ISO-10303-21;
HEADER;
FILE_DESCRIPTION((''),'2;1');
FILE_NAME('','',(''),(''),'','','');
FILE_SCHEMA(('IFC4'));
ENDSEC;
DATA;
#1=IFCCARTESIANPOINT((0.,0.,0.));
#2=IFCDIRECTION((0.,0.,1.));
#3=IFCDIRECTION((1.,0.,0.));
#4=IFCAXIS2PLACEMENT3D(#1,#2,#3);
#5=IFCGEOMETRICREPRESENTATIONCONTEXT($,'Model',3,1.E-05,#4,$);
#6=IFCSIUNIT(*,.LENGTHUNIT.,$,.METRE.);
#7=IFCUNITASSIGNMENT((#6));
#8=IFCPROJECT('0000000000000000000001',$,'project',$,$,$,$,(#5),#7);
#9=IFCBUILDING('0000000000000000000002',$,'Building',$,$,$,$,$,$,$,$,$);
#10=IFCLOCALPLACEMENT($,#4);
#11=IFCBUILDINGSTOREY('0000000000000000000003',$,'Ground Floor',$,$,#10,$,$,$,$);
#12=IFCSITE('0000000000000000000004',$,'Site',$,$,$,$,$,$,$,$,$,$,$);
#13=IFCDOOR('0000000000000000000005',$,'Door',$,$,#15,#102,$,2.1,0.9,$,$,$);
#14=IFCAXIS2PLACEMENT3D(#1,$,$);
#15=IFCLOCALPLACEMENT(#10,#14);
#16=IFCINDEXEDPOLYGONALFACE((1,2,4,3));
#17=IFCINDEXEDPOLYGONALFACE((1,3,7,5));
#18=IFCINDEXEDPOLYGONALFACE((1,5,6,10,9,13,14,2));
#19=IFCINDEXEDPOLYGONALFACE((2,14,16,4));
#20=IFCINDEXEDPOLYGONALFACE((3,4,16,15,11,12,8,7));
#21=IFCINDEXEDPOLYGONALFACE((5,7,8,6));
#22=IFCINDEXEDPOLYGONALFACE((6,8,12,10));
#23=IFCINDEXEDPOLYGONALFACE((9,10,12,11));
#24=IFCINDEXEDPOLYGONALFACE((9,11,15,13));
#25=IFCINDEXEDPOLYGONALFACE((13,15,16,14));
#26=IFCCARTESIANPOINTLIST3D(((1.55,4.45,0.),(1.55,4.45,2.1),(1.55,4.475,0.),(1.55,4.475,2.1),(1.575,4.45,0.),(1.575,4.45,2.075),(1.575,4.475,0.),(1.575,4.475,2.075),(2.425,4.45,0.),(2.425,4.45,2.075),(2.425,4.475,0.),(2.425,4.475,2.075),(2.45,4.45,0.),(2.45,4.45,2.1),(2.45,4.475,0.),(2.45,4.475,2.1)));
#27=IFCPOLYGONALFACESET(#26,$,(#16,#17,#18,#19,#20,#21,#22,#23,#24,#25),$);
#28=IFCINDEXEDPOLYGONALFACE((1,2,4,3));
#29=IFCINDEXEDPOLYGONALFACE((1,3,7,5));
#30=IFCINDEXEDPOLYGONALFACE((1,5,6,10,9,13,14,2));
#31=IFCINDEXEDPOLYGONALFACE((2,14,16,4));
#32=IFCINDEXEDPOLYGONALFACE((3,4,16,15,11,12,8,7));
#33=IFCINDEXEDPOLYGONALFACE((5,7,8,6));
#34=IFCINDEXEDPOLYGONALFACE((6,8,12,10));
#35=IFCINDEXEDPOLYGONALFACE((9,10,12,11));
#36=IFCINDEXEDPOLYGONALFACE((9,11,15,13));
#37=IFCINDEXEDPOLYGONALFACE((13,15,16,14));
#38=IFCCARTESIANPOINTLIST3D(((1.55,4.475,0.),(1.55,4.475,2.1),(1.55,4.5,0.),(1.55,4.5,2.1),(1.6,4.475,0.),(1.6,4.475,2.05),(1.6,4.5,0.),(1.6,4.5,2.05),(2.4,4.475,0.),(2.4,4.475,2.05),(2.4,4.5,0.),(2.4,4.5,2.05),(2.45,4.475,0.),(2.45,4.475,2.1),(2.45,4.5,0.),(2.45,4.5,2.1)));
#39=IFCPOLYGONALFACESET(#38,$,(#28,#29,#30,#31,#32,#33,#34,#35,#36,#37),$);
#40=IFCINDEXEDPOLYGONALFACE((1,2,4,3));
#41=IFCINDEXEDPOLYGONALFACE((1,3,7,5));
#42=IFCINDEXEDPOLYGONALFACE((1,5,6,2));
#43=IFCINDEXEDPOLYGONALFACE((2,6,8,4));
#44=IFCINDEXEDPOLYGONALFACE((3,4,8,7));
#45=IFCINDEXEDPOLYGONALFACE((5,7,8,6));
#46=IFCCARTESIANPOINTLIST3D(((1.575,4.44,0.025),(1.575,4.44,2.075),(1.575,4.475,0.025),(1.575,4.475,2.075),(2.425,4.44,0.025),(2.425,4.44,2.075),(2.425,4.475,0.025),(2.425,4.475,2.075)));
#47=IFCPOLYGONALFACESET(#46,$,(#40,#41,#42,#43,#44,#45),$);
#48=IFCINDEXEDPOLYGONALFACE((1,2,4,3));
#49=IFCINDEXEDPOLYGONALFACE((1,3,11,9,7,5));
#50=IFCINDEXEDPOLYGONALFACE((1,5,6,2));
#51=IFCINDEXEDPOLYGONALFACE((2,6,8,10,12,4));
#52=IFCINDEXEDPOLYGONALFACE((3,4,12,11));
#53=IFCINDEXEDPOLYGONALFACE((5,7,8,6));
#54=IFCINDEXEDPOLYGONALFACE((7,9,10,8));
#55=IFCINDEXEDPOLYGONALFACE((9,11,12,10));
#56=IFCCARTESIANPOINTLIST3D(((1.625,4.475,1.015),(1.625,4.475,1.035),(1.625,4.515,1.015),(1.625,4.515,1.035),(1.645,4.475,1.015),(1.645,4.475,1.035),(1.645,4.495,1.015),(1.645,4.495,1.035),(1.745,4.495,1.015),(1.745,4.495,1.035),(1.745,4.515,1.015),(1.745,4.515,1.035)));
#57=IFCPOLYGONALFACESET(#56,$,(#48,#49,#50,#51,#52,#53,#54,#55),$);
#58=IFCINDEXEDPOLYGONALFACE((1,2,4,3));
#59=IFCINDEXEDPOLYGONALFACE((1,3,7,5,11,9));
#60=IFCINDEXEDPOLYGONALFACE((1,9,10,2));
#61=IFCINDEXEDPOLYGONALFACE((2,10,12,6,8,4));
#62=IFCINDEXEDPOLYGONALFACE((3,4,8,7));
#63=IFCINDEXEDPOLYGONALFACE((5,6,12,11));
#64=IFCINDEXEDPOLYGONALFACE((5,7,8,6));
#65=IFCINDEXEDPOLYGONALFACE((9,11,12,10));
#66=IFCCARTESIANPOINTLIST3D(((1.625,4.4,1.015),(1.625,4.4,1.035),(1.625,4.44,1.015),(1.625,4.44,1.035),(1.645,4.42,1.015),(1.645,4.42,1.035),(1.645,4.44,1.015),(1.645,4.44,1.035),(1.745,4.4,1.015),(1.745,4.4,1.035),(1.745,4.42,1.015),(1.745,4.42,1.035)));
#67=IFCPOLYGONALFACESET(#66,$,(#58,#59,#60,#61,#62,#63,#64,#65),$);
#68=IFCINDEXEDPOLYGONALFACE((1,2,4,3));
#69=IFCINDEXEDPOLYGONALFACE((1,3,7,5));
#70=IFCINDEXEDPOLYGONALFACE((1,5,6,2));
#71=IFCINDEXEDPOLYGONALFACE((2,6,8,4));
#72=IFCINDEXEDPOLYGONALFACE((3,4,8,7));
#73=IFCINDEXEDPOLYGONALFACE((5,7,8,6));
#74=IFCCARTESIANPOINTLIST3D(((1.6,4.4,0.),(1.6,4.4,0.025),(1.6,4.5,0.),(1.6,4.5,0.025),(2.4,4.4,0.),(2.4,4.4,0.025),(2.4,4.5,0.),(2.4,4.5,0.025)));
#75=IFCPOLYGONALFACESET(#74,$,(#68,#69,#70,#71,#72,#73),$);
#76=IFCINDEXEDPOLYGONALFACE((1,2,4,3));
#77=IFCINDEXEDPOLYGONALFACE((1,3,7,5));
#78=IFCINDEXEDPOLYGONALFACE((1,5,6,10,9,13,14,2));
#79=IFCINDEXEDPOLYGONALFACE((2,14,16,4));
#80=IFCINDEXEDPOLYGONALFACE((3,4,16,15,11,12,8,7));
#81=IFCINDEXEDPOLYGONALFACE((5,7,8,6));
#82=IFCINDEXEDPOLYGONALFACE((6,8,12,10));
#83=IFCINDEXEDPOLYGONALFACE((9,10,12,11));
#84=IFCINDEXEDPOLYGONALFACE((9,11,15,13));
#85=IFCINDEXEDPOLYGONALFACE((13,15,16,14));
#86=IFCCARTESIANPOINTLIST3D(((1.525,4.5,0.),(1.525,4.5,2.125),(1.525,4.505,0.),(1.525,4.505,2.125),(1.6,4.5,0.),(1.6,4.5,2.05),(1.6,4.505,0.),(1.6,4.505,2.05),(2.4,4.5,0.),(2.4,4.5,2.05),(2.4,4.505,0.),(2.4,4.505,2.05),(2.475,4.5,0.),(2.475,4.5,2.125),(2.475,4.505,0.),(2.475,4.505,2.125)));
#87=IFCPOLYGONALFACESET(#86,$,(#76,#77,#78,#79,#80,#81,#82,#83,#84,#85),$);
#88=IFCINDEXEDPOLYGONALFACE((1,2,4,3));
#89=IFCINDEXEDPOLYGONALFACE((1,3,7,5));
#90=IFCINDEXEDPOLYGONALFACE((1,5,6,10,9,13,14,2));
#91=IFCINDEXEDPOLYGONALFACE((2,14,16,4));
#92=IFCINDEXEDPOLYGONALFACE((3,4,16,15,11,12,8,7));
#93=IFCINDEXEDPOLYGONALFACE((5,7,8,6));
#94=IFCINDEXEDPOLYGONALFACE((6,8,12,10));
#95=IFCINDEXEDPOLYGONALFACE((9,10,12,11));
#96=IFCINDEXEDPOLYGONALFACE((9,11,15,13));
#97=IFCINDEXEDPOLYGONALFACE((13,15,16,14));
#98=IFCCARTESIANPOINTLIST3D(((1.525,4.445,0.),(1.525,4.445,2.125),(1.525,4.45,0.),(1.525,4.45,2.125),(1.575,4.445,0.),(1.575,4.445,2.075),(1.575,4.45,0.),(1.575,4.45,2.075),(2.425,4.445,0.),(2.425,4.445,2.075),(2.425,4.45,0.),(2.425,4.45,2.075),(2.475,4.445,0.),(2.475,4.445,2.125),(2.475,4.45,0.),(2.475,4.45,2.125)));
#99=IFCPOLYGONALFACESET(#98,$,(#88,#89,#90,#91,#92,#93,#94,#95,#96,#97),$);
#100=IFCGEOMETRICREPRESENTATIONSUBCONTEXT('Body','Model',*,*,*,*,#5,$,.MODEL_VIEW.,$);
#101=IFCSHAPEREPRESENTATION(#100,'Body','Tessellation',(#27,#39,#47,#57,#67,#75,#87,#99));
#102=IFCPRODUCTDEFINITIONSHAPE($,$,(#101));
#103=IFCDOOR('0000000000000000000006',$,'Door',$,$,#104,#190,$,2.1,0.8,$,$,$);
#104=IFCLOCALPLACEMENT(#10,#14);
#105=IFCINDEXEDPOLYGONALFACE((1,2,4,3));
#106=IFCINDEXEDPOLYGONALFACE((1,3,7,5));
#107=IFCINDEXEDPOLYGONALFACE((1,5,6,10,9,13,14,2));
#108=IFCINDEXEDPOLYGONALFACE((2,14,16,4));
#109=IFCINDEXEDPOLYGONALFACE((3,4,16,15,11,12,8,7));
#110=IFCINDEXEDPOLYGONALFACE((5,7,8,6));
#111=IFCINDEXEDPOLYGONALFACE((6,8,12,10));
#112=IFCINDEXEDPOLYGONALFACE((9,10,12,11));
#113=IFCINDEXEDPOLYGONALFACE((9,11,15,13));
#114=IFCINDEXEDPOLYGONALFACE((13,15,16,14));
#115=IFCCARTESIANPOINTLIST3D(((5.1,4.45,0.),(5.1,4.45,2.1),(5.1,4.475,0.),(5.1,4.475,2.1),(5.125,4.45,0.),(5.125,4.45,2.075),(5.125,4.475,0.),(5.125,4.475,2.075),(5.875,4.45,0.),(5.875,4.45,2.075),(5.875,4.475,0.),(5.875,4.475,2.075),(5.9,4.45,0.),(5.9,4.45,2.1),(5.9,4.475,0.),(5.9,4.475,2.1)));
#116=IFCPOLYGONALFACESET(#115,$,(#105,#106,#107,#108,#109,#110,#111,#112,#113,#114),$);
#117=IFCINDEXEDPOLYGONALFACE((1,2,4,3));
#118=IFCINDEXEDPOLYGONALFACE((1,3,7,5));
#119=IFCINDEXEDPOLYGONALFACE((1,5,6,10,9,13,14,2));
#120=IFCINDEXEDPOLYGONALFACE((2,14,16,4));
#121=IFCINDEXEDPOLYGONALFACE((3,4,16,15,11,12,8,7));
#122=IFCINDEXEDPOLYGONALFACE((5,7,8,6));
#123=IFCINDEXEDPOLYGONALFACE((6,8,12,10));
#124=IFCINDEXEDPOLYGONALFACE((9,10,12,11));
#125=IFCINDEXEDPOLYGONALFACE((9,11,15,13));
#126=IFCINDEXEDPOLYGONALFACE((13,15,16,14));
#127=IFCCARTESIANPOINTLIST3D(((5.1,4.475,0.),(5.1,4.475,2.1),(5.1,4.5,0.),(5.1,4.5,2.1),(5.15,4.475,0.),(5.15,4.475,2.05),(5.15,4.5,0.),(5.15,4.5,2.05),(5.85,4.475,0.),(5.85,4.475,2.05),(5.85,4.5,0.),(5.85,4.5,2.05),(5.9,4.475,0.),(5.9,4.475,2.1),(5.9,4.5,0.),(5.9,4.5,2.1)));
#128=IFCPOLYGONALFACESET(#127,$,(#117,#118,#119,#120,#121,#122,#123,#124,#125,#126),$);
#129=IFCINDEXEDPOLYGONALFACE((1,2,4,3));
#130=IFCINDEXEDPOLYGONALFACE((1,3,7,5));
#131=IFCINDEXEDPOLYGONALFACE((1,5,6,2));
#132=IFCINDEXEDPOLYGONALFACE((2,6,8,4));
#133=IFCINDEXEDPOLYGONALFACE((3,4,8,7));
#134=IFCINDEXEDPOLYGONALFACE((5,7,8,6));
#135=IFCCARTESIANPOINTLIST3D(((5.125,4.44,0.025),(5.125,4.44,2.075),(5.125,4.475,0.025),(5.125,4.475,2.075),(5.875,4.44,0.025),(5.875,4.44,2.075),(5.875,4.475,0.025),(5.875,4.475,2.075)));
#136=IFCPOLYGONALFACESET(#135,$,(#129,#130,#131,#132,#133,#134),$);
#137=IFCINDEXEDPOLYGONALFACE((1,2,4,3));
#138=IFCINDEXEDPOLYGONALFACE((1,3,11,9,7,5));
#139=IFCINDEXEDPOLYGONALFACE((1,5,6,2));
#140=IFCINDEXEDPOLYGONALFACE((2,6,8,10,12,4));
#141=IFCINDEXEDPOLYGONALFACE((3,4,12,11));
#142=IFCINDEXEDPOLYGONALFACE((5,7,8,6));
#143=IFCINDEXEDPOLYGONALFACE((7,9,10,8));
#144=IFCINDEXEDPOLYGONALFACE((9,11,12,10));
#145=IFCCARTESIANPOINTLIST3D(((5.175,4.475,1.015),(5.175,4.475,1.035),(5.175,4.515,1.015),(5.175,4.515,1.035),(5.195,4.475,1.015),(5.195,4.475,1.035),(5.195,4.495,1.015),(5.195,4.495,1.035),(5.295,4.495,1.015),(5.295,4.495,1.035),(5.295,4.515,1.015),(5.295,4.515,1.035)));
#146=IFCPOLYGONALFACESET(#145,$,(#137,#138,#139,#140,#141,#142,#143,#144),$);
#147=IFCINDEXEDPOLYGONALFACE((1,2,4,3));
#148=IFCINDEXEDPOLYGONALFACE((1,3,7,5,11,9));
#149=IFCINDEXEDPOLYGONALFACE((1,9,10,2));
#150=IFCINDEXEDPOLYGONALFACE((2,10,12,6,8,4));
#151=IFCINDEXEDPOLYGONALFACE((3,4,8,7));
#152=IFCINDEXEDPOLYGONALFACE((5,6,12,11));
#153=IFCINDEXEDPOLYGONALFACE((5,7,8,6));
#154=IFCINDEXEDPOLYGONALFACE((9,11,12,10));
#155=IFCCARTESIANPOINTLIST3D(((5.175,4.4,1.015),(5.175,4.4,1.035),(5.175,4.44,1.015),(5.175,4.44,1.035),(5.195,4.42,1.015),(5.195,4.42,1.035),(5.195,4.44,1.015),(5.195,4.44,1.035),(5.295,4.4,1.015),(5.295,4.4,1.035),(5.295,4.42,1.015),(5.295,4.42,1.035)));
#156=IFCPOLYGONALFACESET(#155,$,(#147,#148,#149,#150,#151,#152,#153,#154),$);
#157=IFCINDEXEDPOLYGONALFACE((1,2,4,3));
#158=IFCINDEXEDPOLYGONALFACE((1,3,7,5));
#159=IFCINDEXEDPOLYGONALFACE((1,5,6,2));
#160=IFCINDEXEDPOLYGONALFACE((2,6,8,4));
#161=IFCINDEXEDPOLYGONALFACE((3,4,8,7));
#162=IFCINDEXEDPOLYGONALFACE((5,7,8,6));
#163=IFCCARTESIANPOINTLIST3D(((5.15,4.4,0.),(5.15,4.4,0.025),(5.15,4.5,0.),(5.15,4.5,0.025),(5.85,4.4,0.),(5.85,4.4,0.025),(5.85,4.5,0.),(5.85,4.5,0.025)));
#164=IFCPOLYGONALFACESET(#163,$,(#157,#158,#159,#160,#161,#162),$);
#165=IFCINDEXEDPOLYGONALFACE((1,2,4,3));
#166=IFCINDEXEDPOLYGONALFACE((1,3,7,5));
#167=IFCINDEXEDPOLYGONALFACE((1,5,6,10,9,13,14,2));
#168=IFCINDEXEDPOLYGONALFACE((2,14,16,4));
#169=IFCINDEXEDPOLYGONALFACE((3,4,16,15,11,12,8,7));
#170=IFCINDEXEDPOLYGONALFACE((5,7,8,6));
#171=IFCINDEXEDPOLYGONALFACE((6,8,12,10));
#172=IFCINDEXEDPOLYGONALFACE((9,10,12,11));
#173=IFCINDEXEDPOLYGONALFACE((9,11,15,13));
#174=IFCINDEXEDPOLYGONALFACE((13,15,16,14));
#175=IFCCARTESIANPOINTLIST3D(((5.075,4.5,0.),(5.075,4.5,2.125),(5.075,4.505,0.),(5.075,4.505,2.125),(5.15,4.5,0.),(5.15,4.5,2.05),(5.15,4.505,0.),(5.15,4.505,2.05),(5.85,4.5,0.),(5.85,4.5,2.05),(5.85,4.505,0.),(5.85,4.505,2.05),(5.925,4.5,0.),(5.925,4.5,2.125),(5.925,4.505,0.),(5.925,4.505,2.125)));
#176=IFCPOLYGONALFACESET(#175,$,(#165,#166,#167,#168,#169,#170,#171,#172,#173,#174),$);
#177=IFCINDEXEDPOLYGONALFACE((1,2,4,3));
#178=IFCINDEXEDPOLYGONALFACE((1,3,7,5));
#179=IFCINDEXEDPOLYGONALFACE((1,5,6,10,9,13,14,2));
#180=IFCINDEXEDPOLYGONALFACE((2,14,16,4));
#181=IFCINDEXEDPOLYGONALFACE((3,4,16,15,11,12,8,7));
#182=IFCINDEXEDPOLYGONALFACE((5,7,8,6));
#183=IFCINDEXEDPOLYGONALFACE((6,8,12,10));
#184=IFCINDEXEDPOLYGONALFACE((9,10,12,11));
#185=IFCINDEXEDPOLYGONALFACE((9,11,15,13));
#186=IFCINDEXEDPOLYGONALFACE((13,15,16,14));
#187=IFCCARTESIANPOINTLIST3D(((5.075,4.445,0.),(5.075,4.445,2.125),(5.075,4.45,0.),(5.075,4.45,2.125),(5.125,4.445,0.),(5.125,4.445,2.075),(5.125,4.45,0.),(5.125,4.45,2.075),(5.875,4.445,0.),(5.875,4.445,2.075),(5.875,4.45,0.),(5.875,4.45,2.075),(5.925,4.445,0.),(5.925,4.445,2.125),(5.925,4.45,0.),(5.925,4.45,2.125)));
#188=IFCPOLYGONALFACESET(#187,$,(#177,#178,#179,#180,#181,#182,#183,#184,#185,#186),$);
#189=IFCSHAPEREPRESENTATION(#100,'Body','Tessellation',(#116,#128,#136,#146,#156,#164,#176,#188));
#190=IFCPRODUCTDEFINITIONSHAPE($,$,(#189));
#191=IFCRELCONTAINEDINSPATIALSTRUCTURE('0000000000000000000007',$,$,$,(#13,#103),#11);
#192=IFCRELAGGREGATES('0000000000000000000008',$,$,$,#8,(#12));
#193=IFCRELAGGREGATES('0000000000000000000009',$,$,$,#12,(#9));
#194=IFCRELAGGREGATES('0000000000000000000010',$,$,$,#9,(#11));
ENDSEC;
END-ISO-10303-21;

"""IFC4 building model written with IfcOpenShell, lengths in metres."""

from ifc_helpers import new_model, si_unit, frame, origin_with_axes, place, context, subcontext, project, spatial, line, indexed_curve, outline, extrude, element, save


model = new_model("IFC4")

# Units and contexts
model_context = context("Model", 3, precision=1e-05, world=origin_with_axes())
body_context = subcontext(model_context, "Body", "Model", "MODEL_VIEW")
ifc_project = project(units=[si_unit("LENGTHUNIT", "METRE")], contexts=[model_context])

# Site, building, storey
site = spatial("IfcSite", under=ifc_project, Name="Site")
building = spatial("IfcBuilding", under=site, Name="Building")
storey_placement = place(None, origin_with_axes())
storey = spatial("IfcBuildingStorey", under=building, at=storey_placement, Name="Ground Floor")

# Doors
door_1_placement = place(storey_placement, frame((2.45, 4.5, 0.0), z_axis=(0.0, 0.0, 1.0), x_axis=(-1.0, 0.0, 0.0)))
element("IfcDoor", 1, at=door_1_placement, inside=storey, Name="Door", OverallHeight=2.1, OverallWidth=0.9, context=body_context, shape_type="SweptSolid", body=[
    extrude(outline(indexed_curve([(0.0, 0.0), (0.0, 2.1), (0.9, 2.1), (0.9, 0.0), (0.875, 0.0), (0.875, 2.075), (0.025, 2.075), (0.025, 0.0)], segments=[line(1, 2, 3, 4, 5, 6, 7, 8, 1)])), frame((0.0, 0.025, 0.0), z_axis=(0.0, -1.0, 0.0), x_axis=(1.0, 0.0, 0.0)), (0.0, 0.0, -1.0), 0.025),
    extrude(outline(indexed_curve([(0.0, 0.0), (0.0, 2.1), (0.9, 2.1), (0.9, 0.0), (0.85, 0.0), (0.85, 2.05), (0.05, 2.05), (0.05, 0.0)], segments=[line(1, 2, 3, 4, 5, 6, 7, 8, 1)])), frame((0.0, 0.0, 0.0), z_axis=(0.0, -1.0, 0.0), x_axis=(1.0, 0.0, 0.0)), (0.0, 0.0, -1.0), 0.025),
    extrude(outline(indexed_curve([(0.0, 0.0), (0.85, 0.0), (0.85, 0.035), (0.0, 0.035)], segments=[line(1, 2, 3, 4, 1)])), frame((0.025, 0.025, 0.025), z_axis=(0.0, 0.0, 1.0), x_axis=(1.0, 0.0, 0.0)), (0.0, 0.0, 1.0), 2.05),
    extrude(outline(indexed_curve([(0.0, 0.0), (0.0, -0.04), (-0.12, -0.04), (-0.12, -0.02), (-0.02, -0.02), (-0.02, 0.0)], segments=[line(1, 2, 3, 4, 5, 6, 1)])), frame((0.825, 0.025, 1.015), z_axis=(0.0, 0.0, 1.0), x_axis=(1.0, 0.0, 0.0)), (0.0, 0.0, 1.0), 0.02),
    extrude(outline(indexed_curve([(0.0, 0.0), (0.0, 0.04), (-0.12, 0.04), (-0.12, 0.02), (-0.02, 0.02), (-0.02, 0.0)], segments=[line(1, 2, 3, 4, 5, 6, 1)])), frame((0.825, 0.06, 1.015), z_axis=(0.0, 0.0, 1.0), x_axis=(1.0, 0.0, 0.0)), (0.0, 0.0, 1.0), 0.02),
    extrude(outline(indexed_curve([(0.0, 0.0), (0.8, 0.0), (0.8, 0.1), (0.0, 0.1)], segments=[line(1, 2, 3, 4, 1)])), frame((0.05, 0.0, 0.0), z_axis=(0.0, 0.0, 1.0), x_axis=(1.0, 0.0, 0.0)), (0.0, 0.0, 1.0), 0.025),
    extrude(outline(indexed_curve([(0.0, 0.0), (0.0, 2.125), (0.95, 2.125), (0.95, 0.0), (0.875, 0.0), (0.875, 2.05), (0.075, 2.05), (0.075, 0.0)], segments=[line(1, 2, 3, 4, 5, 6, 7, 8, 1)])), frame((-0.025, -0.005, 0.0), z_axis=(0.0, -1.0, 0.0), x_axis=(1.0, 0.0, 0.0)), (0.0, 0.0, -1.0), 0.005),
    extrude(outline(indexed_curve([(0.0, 0.0), (0.0, 2.125), (0.95, 2.125), (0.95, 0.0), (0.9, 0.0), (0.9, 2.075), (0.05, 2.075), (0.05, 0.0)], segments=[line(1, 2, 3, 4, 5, 6, 7, 8, 1)])), frame((-0.025, 0.05, 0.0), z_axis=(0.0, -1.0, 0.0), x_axis=(1.0, 0.0, 0.0)), (0.0, 0.0, -1.0), 0.005),
])
door_2_placement = place(storey_placement, frame((5.9, 4.5, 0.0), z_axis=(0.0, 0.0, 1.0), x_axis=(-1.0, 0.0, 0.0)))
element("IfcDoor", 2, at=door_2_placement, inside=storey, Name="Door", OverallHeight=2.1, OverallWidth=0.8, context=body_context, shape_type="SweptSolid", body=[
    extrude(outline(indexed_curve([(0.0, 0.0), (0.0, 2.1), (0.8, 2.1), (0.8, 0.0), (0.775, 0.0), (0.775, 2.075), (0.025, 2.075), (0.025, 0.0)], segments=[line(1, 2, 3, 4, 5, 6, 7, 8, 1)])), frame((0.0, 0.025, 0.0), z_axis=(0.0, -1.0, 0.0), x_axis=(1.0, 0.0, 0.0)), (0.0, 0.0, -1.0), 0.025),
    extrude(outline(indexed_curve([(0.0, 0.0), (0.0, 2.1), (0.8, 2.1), (0.8, 0.0), (0.75, 0.0), (0.75, 2.05), (0.05, 2.05), (0.05, 0.0)], segments=[line(1, 2, 3, 4, 5, 6, 7, 8, 1)])), frame((0.0, 0.0, 0.0), z_axis=(0.0, -1.0, 0.0), x_axis=(1.0, 0.0, 0.0)), (0.0, 0.0, -1.0), 0.025),
    extrude(outline(indexed_curve([(0.0, 0.0), (0.75, 0.0), (0.75, 0.035), (0.0, 0.035)], segments=[line(1, 2, 3, 4, 1)])), frame((0.025, 0.025, 0.025), z_axis=(0.0, 0.0, 1.0), x_axis=(1.0, 0.0, 0.0)), (0.0, 0.0, 1.0), 2.05),
    extrude(outline(indexed_curve([(0.0, 0.0), (0.0, -0.04), (-0.12, -0.04), (-0.12, -0.02), (-0.02, -0.02), (-0.02, 0.0)], segments=[line(1, 2, 3, 4, 5, 6, 1)])), frame((0.725, 0.025, 1.015), z_axis=(0.0, 0.0, 1.0), x_axis=(1.0, 0.0, 0.0)), (0.0, 0.0, 1.0), 0.02),
    extrude(outline(indexed_curve([(0.0, 0.0), (0.0, 0.04), (-0.12, 0.04), (-0.12, 0.02), (-0.02, 0.02), (-0.02, 0.0)], segments=[line(1, 2, 3, 4, 5, 6, 1)])), frame((0.725, 0.06, 1.015), z_axis=(0.0, 0.0, 1.0), x_axis=(1.0, 0.0, 0.0)), (0.0, 0.0, 1.0), 0.02),
    extrude(outline(indexed_curve([(0.0, 0.0), (0.7, 0.0), (0.7, 0.1), (0.0, 0.1)], segments=[line(1, 2, 3, 4, 1)])), frame((0.05, 0.0, 0.0), z_axis=(0.0, 0.0, 1.0), x_axis=(1.0, 0.0, 0.0)), (0.0, 0.0, 1.0), 0.025),
    extrude(outline(indexed_curve([(0.0, 0.0), (0.0, 2.125), (0.85, 2.125), (0.85, 0.0), (0.775, 0.0), (0.775, 2.05), (0.075, 2.05), (0.075, 0.0)], segments=[line(1, 2, 3, 4, 5, 6, 7, 8, 1)])), frame((-0.025, -0.005, 0.0), z_axis=(0.0, -1.0, 0.0), x_axis=(1.0, 0.0, 0.0)), (0.0, 0.0, -1.0), 0.005),
    extrude(outline(indexed_curve([(0.0, 0.0), (0.0, 2.125), (0.85, 2.125), (0.85, 0.0), (0.8, 0.0), (0.8, 2.075), (0.05, 2.075), (0.05, 0.0)], segments=[line(1, 2, 3, 4, 5, 6, 7, 8, 1)])), frame((-0.025, 0.05, 0.0), z_axis=(0.0, -1.0, 0.0), x_axis=(1.0, 0.0, 0.0)), (0.0, 0.0, -1.0), 0.005),
])

save(model, "model.ifc")
